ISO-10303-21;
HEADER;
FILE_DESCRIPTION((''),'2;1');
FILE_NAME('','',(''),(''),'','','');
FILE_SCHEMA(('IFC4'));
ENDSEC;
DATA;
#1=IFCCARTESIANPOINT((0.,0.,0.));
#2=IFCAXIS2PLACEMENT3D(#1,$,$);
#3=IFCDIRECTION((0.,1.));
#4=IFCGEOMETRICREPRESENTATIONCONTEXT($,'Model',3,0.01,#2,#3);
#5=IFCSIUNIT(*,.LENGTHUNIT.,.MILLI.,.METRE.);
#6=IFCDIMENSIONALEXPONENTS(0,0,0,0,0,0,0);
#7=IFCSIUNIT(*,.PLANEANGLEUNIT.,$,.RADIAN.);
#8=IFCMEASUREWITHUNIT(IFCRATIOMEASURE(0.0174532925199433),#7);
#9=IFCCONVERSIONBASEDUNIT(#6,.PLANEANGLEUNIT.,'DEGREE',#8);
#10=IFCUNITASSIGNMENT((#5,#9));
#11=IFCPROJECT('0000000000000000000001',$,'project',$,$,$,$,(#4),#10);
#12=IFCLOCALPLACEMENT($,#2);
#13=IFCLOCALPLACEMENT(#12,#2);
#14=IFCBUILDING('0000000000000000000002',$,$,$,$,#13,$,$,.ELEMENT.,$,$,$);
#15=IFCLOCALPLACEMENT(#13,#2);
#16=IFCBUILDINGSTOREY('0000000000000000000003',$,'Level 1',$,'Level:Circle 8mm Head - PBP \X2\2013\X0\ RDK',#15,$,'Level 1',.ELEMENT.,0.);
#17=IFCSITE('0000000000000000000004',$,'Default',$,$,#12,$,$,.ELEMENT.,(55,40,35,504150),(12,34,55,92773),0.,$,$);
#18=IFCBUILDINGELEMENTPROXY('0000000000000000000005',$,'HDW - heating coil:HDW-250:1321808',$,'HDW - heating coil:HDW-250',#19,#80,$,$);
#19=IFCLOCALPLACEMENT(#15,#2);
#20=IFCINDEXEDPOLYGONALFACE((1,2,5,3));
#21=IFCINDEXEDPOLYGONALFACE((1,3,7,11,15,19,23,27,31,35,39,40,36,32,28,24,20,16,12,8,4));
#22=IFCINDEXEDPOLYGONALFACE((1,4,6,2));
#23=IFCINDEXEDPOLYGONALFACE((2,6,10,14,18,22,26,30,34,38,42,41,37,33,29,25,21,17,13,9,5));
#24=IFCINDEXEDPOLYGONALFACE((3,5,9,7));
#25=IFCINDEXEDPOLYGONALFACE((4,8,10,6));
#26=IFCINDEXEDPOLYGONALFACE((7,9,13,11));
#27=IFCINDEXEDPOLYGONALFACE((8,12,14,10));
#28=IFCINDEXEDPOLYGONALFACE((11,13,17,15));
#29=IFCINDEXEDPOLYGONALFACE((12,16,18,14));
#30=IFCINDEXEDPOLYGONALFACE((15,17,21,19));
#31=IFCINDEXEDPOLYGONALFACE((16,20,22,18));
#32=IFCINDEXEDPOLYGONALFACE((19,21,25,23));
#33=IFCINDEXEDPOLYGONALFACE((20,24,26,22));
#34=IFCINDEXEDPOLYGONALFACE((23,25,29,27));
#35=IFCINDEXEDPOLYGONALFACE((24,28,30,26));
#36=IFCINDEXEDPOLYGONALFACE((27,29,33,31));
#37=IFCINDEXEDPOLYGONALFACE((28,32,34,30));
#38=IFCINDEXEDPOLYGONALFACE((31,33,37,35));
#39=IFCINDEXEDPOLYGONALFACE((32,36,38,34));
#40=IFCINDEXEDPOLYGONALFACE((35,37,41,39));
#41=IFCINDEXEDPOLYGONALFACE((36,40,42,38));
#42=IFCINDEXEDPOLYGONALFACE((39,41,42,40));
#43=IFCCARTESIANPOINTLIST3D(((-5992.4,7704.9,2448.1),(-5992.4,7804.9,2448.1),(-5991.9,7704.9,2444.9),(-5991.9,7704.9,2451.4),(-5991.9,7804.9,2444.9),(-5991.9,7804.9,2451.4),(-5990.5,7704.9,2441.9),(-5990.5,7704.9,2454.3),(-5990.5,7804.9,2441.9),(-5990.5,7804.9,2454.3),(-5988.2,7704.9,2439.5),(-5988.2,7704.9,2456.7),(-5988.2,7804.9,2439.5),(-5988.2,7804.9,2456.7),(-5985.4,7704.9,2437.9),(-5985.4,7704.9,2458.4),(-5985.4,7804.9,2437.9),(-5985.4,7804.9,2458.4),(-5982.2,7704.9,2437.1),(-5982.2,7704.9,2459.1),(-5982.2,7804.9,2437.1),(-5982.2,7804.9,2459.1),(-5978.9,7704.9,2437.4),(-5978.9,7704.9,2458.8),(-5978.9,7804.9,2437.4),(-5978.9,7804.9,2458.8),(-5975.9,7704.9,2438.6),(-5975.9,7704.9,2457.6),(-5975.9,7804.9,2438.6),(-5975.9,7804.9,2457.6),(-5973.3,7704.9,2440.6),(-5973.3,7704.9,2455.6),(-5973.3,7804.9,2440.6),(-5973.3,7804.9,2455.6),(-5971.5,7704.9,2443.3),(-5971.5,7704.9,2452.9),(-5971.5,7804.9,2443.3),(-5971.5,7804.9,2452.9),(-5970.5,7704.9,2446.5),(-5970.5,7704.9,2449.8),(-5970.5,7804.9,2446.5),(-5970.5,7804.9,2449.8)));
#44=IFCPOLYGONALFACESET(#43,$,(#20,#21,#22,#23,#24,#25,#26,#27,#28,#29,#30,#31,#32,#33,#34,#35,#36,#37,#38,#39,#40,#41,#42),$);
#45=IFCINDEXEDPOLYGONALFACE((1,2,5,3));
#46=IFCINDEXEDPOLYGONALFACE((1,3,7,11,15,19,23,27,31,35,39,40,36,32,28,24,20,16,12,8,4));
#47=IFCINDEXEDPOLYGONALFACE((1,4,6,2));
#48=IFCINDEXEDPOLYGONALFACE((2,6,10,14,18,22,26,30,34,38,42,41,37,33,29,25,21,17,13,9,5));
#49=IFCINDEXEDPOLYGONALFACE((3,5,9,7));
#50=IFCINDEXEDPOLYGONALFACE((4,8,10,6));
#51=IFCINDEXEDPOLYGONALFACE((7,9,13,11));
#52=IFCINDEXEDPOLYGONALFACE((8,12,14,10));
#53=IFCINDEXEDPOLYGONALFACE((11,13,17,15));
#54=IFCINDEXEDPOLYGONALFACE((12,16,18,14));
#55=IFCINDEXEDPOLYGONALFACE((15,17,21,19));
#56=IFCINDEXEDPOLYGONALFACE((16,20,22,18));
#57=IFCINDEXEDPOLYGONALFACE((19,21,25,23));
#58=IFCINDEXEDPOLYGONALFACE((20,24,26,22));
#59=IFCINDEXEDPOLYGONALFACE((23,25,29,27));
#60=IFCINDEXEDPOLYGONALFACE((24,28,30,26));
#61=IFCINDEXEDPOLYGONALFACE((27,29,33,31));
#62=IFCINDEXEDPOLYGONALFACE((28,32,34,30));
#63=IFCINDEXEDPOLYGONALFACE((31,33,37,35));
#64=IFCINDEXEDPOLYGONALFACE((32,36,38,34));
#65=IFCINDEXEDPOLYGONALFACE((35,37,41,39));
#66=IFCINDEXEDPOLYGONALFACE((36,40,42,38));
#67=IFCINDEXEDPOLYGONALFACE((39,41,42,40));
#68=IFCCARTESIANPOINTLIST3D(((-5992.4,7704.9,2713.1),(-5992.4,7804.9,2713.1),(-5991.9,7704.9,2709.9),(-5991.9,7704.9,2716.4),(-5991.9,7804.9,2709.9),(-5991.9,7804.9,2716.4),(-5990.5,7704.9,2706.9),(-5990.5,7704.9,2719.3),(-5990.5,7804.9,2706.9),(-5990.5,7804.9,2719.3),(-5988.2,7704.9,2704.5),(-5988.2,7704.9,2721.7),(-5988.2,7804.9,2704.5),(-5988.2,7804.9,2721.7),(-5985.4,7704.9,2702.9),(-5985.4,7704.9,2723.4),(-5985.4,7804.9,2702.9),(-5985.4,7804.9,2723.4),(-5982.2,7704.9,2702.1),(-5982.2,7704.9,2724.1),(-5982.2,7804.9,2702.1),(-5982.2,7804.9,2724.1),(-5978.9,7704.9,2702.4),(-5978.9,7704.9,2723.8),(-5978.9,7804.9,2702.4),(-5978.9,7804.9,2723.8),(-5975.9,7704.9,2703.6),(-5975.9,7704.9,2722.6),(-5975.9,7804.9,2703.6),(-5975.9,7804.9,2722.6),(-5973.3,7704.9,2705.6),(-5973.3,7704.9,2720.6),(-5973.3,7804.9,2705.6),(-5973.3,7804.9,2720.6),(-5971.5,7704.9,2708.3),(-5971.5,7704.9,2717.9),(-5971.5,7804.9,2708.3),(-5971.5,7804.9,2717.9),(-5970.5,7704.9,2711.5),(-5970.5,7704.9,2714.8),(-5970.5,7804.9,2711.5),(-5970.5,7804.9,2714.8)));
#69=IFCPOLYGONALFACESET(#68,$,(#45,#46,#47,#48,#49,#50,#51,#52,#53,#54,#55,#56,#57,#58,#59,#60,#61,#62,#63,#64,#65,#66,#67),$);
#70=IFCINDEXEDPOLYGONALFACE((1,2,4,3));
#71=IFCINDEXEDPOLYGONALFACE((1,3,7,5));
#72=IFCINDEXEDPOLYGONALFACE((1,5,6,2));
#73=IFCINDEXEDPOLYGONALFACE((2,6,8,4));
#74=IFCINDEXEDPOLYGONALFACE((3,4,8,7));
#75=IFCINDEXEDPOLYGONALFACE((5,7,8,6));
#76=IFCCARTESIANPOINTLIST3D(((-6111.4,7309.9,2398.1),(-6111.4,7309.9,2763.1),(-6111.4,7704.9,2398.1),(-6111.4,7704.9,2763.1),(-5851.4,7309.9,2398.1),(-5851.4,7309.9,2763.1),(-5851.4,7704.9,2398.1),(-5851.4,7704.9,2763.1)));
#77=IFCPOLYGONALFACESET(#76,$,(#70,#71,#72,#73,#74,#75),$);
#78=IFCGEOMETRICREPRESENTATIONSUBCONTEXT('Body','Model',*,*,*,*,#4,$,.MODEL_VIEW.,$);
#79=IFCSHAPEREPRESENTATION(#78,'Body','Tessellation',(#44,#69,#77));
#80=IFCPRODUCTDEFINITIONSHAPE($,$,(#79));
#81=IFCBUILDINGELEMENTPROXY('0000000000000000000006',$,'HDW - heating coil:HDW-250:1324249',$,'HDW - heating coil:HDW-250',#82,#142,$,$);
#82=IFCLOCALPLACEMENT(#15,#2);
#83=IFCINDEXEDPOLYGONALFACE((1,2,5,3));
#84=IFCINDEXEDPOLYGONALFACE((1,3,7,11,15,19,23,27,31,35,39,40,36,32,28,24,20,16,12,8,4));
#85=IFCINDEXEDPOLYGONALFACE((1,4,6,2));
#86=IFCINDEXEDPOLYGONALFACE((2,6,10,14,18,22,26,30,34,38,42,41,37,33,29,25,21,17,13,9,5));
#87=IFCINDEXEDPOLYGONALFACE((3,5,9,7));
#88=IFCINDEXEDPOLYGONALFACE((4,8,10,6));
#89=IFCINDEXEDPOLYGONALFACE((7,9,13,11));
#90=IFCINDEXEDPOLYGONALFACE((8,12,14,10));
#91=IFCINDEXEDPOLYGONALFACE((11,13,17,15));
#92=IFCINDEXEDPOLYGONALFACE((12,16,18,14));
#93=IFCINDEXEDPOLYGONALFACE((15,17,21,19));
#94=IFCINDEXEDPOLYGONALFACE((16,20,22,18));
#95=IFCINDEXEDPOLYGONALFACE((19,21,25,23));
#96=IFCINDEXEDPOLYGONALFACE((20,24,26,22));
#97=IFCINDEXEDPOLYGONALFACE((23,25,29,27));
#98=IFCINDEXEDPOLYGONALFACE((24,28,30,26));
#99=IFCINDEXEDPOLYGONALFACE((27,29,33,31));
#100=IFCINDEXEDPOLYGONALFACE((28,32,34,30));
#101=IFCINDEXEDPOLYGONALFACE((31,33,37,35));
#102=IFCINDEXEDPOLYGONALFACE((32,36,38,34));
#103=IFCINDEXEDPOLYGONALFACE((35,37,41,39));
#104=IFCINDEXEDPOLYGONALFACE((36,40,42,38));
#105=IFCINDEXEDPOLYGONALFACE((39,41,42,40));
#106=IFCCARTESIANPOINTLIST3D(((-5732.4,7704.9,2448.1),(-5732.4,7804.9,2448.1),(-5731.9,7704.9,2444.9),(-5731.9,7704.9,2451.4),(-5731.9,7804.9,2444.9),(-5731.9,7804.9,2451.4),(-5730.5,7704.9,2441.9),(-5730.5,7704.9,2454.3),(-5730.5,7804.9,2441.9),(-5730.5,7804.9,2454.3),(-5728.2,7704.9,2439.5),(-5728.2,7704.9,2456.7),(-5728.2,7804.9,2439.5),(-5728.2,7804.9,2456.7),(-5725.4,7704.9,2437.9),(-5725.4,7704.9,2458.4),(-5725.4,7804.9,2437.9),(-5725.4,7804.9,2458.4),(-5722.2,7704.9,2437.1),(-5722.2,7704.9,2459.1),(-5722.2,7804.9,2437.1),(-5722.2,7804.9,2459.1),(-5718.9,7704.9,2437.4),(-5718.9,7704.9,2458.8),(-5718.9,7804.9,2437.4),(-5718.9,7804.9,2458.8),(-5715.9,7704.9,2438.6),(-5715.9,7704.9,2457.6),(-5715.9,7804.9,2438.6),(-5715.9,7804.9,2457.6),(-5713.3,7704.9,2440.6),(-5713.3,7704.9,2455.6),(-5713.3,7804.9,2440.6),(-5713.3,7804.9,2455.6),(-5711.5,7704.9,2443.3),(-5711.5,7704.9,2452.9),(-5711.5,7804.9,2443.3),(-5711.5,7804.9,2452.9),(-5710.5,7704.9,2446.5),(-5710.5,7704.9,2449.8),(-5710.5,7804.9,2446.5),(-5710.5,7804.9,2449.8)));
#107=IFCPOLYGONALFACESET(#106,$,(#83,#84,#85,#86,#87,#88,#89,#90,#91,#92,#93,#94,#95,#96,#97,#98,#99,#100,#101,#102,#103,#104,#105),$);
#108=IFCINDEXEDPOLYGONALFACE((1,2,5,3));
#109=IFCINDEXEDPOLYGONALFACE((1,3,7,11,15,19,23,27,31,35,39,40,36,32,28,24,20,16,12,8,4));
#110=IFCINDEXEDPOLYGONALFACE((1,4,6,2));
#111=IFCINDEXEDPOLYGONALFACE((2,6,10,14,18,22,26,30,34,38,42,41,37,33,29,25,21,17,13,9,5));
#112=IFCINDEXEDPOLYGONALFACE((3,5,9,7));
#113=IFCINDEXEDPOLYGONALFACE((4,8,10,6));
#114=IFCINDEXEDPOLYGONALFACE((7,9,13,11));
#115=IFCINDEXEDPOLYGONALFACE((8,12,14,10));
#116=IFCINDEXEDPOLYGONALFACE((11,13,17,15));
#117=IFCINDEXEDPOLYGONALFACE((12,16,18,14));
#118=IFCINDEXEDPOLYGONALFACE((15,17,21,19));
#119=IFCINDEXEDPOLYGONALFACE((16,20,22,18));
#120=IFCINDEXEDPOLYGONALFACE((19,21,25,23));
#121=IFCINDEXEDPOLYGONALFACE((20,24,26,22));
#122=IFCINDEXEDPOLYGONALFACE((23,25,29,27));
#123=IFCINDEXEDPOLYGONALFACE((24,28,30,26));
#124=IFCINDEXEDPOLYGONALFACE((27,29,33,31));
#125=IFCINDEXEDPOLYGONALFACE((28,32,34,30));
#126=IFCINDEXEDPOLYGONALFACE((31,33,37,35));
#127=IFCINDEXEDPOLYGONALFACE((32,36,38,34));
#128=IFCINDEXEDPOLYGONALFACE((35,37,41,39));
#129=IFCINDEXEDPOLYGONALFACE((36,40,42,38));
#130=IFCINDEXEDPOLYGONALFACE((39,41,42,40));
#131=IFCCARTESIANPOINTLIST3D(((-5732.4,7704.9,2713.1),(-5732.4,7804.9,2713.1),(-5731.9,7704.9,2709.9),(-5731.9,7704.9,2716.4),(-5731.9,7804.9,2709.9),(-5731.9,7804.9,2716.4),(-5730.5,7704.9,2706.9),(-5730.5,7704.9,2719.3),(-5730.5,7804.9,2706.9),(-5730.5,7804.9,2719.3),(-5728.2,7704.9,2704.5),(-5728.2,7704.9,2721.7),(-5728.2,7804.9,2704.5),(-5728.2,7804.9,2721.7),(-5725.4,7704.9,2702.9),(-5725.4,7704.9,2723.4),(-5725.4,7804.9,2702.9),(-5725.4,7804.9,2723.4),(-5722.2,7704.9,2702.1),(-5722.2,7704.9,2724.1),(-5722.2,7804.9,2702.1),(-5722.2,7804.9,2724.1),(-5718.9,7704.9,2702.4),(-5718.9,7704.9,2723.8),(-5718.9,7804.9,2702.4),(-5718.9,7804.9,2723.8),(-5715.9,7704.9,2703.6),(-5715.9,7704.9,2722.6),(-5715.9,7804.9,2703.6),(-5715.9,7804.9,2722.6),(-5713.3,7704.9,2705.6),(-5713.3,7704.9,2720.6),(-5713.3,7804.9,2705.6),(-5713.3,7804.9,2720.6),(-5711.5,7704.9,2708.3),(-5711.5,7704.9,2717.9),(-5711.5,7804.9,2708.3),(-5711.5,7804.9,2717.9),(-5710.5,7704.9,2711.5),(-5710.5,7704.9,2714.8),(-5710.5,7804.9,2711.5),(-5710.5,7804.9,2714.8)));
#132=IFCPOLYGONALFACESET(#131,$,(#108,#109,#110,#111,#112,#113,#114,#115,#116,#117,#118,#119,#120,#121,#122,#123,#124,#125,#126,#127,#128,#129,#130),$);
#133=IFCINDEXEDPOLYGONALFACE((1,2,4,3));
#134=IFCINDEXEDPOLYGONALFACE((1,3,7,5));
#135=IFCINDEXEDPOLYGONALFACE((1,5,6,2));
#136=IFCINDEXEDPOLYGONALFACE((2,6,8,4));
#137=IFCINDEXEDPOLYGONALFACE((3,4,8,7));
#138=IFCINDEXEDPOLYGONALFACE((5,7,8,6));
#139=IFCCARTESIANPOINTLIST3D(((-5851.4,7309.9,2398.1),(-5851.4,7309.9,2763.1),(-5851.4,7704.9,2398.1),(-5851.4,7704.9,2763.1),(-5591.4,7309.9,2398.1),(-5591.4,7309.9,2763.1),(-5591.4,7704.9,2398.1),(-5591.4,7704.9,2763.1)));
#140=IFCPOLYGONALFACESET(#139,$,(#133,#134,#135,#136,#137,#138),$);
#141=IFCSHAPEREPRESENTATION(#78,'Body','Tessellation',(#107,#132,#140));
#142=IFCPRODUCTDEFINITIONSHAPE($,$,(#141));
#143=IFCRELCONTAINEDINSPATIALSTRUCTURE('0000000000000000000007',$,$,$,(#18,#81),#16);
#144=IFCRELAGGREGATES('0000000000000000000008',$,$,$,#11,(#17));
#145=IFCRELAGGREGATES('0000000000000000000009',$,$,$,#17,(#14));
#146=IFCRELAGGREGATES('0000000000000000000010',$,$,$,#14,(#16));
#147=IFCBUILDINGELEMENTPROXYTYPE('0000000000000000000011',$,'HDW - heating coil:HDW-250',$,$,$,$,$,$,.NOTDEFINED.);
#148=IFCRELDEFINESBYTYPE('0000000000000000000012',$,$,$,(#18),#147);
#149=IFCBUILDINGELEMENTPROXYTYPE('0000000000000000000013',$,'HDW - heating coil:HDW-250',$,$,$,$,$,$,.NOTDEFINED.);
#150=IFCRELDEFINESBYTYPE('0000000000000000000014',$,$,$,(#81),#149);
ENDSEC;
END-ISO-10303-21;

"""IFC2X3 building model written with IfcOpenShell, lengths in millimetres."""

from ifc_helpers import new_model, entity, si_unit, converted_unit, direction, frame, frame_2d, origin, origin_2d_with_axis, place, context, subcontext, project, spatial, rectangle, circle, extrude, source, transform, mapped, type_object, type_shapes, element, save


model = new_model("IFC2X3")

# Units and contexts
model_context = context("Model", 3, precision=0.01, world=origin(), true_north=direction((0.0, 1.0)))
body_context = subcontext(model_context, "Body", "Model", "MODEL_VIEW")
ifc_project = project(units=[si_unit("LENGTHUNIT", "METRE", prefix="MILLI"), converted_unit("PLANEANGLEUNIT", "DEGREE", entity("IfcRatioMeasure", 0.0174532925199433), si_unit("PLANEANGLEUNIT", "RADIAN"), dimensions=[0, 0, 0, 0, 0, 0, 0])], contexts=[model_context])

# Site, building, storey
site_placement = place(None, origin())
site = spatial("IfcSite", under=ifc_project, at=site_placement, Name="Default", CompositionType="ELEMENT", RefLatitude=(55, 40, 35, 504150), RefLongitude=(12, 34, 55, 92773), RefElevation=0.0)
building_placement = place(site_placement, origin())
building = spatial("IfcBuilding", under=site, at=building_placement, CompositionType="ELEMENT")
storey_placement = place(building_placement, origin())
storey = spatial("IfcBuildingStorey", under=building, at=storey_placement, Name="Level 1", ObjectType="Level:Circle 8mm Head - PBP – RDK", LongName="Level 1", CompositionType="ELEMENT", Elevation=0.0)

# Building element proxies
building_element_proxy_type_1 = type_object("IfcBuildingElementProxyType", Name="HDW - heating coil:HDW-250", PredefinedType="NOTDEFINED")
shared_shape_1 = source(origin(), body_context, "Body", "SweptSolid", [
    extrude(circle(Radius=11.0, at=frame_2d((0.0, 0.0), x_axis=(1.0, 0.0))), frame((0.0, -297.5, -132.5), z_axis=(0.0, 1.0, 0.0), x_axis=(1.0, 0.0, 0.0)), (0.0, 0.0, 1.0), 100.0),
    extrude(circle(Radius=11.0, at=frame_2d((0.0, 0.0), x_axis=(1.0, 0.0))), frame((0.0, -297.5, 132.5), z_axis=(0.0, 1.0, 0.0), x_axis=(1.0, 0.0, 0.0)), (0.0, 0.0, 1.0), 100.0),
    extrude(rectangle(XDim=260.0, YDim=395.0, at=origin_2d_with_axis()), frame((0.0, 0.0, -182.5)), (0.0, 0.0, 1.0), 365.0),
])
type_shapes(building_element_proxy_type_1, [shared_shape_1])
proxy_1_placement = place(storey_placement, frame((-5981.4, 7507.4, 2580.6), z_axis=(0.0, 0.0, 1.0), x_axis=(-1.0, 0.0, 0.0)))
element("IfcBuildingElementProxy", 1, at=proxy_1_placement, inside=storey, type_object=building_element_proxy_type_1, Name="HDW - heating coil:HDW-250:1321808", ObjectType="HDW - heating coil:HDW-250", context=body_context, shape_type="MappedRepresentation", body=[
    mapped(shared_shape_1, transform((0.0, 0.0, 0.0), scale=1.0)),
])
building_element_proxy_type_2 = type_object("IfcBuildingElementProxyType", Name="HDW - heating coil:HDW-250", PredefinedType="NOTDEFINED")
shared_shape_2 = source(origin(), body_context, "Body", "SweptSolid", [
    extrude(circle(Radius=11.0, at=frame_2d((0.0, 0.0), x_axis=(1.0, 0.0))), frame((0.0, -297.5, -132.5), z_axis=(0.0, 1.0, 0.0), x_axis=(1.0, 0.0, 0.0)), (0.0, 0.0, 1.0), 100.0),
    extrude(circle(Radius=11.0, at=frame_2d((0.0, 0.0), x_axis=(1.0, 0.0))), frame((0.0, -297.5, 132.5), z_axis=(0.0, 1.0, 0.0), x_axis=(1.0, 0.0, 0.0)), (0.0, 0.0, 1.0), 100.0),
    extrude(rectangle(XDim=260.0, YDim=395.0, at=origin_2d_with_axis()), frame((0.0, 0.0, -182.5)), (0.0, 0.0, 1.0), 365.0),
])
type_shapes(building_element_proxy_type_2, [shared_shape_2])
proxy_2_placement = place(storey_placement, frame((-5721.4, 7507.4, 2580.6), z_axis=(0.0, 0.0, 1.0), x_axis=(-1.0, 0.0, 0.0)))
element("IfcBuildingElementProxy", 2, at=proxy_2_placement, inside=storey, type_object=building_element_proxy_type_2, Name="HDW - heating coil:HDW-250:1324249", ObjectType="HDW - heating coil:HDW-250", context=body_context, shape_type="MappedRepresentation", body=[
    mapped(shared_shape_2, transform((0.0, 0.0, 0.0), scale=1.0)),
])

save(model, "model.ifc")
